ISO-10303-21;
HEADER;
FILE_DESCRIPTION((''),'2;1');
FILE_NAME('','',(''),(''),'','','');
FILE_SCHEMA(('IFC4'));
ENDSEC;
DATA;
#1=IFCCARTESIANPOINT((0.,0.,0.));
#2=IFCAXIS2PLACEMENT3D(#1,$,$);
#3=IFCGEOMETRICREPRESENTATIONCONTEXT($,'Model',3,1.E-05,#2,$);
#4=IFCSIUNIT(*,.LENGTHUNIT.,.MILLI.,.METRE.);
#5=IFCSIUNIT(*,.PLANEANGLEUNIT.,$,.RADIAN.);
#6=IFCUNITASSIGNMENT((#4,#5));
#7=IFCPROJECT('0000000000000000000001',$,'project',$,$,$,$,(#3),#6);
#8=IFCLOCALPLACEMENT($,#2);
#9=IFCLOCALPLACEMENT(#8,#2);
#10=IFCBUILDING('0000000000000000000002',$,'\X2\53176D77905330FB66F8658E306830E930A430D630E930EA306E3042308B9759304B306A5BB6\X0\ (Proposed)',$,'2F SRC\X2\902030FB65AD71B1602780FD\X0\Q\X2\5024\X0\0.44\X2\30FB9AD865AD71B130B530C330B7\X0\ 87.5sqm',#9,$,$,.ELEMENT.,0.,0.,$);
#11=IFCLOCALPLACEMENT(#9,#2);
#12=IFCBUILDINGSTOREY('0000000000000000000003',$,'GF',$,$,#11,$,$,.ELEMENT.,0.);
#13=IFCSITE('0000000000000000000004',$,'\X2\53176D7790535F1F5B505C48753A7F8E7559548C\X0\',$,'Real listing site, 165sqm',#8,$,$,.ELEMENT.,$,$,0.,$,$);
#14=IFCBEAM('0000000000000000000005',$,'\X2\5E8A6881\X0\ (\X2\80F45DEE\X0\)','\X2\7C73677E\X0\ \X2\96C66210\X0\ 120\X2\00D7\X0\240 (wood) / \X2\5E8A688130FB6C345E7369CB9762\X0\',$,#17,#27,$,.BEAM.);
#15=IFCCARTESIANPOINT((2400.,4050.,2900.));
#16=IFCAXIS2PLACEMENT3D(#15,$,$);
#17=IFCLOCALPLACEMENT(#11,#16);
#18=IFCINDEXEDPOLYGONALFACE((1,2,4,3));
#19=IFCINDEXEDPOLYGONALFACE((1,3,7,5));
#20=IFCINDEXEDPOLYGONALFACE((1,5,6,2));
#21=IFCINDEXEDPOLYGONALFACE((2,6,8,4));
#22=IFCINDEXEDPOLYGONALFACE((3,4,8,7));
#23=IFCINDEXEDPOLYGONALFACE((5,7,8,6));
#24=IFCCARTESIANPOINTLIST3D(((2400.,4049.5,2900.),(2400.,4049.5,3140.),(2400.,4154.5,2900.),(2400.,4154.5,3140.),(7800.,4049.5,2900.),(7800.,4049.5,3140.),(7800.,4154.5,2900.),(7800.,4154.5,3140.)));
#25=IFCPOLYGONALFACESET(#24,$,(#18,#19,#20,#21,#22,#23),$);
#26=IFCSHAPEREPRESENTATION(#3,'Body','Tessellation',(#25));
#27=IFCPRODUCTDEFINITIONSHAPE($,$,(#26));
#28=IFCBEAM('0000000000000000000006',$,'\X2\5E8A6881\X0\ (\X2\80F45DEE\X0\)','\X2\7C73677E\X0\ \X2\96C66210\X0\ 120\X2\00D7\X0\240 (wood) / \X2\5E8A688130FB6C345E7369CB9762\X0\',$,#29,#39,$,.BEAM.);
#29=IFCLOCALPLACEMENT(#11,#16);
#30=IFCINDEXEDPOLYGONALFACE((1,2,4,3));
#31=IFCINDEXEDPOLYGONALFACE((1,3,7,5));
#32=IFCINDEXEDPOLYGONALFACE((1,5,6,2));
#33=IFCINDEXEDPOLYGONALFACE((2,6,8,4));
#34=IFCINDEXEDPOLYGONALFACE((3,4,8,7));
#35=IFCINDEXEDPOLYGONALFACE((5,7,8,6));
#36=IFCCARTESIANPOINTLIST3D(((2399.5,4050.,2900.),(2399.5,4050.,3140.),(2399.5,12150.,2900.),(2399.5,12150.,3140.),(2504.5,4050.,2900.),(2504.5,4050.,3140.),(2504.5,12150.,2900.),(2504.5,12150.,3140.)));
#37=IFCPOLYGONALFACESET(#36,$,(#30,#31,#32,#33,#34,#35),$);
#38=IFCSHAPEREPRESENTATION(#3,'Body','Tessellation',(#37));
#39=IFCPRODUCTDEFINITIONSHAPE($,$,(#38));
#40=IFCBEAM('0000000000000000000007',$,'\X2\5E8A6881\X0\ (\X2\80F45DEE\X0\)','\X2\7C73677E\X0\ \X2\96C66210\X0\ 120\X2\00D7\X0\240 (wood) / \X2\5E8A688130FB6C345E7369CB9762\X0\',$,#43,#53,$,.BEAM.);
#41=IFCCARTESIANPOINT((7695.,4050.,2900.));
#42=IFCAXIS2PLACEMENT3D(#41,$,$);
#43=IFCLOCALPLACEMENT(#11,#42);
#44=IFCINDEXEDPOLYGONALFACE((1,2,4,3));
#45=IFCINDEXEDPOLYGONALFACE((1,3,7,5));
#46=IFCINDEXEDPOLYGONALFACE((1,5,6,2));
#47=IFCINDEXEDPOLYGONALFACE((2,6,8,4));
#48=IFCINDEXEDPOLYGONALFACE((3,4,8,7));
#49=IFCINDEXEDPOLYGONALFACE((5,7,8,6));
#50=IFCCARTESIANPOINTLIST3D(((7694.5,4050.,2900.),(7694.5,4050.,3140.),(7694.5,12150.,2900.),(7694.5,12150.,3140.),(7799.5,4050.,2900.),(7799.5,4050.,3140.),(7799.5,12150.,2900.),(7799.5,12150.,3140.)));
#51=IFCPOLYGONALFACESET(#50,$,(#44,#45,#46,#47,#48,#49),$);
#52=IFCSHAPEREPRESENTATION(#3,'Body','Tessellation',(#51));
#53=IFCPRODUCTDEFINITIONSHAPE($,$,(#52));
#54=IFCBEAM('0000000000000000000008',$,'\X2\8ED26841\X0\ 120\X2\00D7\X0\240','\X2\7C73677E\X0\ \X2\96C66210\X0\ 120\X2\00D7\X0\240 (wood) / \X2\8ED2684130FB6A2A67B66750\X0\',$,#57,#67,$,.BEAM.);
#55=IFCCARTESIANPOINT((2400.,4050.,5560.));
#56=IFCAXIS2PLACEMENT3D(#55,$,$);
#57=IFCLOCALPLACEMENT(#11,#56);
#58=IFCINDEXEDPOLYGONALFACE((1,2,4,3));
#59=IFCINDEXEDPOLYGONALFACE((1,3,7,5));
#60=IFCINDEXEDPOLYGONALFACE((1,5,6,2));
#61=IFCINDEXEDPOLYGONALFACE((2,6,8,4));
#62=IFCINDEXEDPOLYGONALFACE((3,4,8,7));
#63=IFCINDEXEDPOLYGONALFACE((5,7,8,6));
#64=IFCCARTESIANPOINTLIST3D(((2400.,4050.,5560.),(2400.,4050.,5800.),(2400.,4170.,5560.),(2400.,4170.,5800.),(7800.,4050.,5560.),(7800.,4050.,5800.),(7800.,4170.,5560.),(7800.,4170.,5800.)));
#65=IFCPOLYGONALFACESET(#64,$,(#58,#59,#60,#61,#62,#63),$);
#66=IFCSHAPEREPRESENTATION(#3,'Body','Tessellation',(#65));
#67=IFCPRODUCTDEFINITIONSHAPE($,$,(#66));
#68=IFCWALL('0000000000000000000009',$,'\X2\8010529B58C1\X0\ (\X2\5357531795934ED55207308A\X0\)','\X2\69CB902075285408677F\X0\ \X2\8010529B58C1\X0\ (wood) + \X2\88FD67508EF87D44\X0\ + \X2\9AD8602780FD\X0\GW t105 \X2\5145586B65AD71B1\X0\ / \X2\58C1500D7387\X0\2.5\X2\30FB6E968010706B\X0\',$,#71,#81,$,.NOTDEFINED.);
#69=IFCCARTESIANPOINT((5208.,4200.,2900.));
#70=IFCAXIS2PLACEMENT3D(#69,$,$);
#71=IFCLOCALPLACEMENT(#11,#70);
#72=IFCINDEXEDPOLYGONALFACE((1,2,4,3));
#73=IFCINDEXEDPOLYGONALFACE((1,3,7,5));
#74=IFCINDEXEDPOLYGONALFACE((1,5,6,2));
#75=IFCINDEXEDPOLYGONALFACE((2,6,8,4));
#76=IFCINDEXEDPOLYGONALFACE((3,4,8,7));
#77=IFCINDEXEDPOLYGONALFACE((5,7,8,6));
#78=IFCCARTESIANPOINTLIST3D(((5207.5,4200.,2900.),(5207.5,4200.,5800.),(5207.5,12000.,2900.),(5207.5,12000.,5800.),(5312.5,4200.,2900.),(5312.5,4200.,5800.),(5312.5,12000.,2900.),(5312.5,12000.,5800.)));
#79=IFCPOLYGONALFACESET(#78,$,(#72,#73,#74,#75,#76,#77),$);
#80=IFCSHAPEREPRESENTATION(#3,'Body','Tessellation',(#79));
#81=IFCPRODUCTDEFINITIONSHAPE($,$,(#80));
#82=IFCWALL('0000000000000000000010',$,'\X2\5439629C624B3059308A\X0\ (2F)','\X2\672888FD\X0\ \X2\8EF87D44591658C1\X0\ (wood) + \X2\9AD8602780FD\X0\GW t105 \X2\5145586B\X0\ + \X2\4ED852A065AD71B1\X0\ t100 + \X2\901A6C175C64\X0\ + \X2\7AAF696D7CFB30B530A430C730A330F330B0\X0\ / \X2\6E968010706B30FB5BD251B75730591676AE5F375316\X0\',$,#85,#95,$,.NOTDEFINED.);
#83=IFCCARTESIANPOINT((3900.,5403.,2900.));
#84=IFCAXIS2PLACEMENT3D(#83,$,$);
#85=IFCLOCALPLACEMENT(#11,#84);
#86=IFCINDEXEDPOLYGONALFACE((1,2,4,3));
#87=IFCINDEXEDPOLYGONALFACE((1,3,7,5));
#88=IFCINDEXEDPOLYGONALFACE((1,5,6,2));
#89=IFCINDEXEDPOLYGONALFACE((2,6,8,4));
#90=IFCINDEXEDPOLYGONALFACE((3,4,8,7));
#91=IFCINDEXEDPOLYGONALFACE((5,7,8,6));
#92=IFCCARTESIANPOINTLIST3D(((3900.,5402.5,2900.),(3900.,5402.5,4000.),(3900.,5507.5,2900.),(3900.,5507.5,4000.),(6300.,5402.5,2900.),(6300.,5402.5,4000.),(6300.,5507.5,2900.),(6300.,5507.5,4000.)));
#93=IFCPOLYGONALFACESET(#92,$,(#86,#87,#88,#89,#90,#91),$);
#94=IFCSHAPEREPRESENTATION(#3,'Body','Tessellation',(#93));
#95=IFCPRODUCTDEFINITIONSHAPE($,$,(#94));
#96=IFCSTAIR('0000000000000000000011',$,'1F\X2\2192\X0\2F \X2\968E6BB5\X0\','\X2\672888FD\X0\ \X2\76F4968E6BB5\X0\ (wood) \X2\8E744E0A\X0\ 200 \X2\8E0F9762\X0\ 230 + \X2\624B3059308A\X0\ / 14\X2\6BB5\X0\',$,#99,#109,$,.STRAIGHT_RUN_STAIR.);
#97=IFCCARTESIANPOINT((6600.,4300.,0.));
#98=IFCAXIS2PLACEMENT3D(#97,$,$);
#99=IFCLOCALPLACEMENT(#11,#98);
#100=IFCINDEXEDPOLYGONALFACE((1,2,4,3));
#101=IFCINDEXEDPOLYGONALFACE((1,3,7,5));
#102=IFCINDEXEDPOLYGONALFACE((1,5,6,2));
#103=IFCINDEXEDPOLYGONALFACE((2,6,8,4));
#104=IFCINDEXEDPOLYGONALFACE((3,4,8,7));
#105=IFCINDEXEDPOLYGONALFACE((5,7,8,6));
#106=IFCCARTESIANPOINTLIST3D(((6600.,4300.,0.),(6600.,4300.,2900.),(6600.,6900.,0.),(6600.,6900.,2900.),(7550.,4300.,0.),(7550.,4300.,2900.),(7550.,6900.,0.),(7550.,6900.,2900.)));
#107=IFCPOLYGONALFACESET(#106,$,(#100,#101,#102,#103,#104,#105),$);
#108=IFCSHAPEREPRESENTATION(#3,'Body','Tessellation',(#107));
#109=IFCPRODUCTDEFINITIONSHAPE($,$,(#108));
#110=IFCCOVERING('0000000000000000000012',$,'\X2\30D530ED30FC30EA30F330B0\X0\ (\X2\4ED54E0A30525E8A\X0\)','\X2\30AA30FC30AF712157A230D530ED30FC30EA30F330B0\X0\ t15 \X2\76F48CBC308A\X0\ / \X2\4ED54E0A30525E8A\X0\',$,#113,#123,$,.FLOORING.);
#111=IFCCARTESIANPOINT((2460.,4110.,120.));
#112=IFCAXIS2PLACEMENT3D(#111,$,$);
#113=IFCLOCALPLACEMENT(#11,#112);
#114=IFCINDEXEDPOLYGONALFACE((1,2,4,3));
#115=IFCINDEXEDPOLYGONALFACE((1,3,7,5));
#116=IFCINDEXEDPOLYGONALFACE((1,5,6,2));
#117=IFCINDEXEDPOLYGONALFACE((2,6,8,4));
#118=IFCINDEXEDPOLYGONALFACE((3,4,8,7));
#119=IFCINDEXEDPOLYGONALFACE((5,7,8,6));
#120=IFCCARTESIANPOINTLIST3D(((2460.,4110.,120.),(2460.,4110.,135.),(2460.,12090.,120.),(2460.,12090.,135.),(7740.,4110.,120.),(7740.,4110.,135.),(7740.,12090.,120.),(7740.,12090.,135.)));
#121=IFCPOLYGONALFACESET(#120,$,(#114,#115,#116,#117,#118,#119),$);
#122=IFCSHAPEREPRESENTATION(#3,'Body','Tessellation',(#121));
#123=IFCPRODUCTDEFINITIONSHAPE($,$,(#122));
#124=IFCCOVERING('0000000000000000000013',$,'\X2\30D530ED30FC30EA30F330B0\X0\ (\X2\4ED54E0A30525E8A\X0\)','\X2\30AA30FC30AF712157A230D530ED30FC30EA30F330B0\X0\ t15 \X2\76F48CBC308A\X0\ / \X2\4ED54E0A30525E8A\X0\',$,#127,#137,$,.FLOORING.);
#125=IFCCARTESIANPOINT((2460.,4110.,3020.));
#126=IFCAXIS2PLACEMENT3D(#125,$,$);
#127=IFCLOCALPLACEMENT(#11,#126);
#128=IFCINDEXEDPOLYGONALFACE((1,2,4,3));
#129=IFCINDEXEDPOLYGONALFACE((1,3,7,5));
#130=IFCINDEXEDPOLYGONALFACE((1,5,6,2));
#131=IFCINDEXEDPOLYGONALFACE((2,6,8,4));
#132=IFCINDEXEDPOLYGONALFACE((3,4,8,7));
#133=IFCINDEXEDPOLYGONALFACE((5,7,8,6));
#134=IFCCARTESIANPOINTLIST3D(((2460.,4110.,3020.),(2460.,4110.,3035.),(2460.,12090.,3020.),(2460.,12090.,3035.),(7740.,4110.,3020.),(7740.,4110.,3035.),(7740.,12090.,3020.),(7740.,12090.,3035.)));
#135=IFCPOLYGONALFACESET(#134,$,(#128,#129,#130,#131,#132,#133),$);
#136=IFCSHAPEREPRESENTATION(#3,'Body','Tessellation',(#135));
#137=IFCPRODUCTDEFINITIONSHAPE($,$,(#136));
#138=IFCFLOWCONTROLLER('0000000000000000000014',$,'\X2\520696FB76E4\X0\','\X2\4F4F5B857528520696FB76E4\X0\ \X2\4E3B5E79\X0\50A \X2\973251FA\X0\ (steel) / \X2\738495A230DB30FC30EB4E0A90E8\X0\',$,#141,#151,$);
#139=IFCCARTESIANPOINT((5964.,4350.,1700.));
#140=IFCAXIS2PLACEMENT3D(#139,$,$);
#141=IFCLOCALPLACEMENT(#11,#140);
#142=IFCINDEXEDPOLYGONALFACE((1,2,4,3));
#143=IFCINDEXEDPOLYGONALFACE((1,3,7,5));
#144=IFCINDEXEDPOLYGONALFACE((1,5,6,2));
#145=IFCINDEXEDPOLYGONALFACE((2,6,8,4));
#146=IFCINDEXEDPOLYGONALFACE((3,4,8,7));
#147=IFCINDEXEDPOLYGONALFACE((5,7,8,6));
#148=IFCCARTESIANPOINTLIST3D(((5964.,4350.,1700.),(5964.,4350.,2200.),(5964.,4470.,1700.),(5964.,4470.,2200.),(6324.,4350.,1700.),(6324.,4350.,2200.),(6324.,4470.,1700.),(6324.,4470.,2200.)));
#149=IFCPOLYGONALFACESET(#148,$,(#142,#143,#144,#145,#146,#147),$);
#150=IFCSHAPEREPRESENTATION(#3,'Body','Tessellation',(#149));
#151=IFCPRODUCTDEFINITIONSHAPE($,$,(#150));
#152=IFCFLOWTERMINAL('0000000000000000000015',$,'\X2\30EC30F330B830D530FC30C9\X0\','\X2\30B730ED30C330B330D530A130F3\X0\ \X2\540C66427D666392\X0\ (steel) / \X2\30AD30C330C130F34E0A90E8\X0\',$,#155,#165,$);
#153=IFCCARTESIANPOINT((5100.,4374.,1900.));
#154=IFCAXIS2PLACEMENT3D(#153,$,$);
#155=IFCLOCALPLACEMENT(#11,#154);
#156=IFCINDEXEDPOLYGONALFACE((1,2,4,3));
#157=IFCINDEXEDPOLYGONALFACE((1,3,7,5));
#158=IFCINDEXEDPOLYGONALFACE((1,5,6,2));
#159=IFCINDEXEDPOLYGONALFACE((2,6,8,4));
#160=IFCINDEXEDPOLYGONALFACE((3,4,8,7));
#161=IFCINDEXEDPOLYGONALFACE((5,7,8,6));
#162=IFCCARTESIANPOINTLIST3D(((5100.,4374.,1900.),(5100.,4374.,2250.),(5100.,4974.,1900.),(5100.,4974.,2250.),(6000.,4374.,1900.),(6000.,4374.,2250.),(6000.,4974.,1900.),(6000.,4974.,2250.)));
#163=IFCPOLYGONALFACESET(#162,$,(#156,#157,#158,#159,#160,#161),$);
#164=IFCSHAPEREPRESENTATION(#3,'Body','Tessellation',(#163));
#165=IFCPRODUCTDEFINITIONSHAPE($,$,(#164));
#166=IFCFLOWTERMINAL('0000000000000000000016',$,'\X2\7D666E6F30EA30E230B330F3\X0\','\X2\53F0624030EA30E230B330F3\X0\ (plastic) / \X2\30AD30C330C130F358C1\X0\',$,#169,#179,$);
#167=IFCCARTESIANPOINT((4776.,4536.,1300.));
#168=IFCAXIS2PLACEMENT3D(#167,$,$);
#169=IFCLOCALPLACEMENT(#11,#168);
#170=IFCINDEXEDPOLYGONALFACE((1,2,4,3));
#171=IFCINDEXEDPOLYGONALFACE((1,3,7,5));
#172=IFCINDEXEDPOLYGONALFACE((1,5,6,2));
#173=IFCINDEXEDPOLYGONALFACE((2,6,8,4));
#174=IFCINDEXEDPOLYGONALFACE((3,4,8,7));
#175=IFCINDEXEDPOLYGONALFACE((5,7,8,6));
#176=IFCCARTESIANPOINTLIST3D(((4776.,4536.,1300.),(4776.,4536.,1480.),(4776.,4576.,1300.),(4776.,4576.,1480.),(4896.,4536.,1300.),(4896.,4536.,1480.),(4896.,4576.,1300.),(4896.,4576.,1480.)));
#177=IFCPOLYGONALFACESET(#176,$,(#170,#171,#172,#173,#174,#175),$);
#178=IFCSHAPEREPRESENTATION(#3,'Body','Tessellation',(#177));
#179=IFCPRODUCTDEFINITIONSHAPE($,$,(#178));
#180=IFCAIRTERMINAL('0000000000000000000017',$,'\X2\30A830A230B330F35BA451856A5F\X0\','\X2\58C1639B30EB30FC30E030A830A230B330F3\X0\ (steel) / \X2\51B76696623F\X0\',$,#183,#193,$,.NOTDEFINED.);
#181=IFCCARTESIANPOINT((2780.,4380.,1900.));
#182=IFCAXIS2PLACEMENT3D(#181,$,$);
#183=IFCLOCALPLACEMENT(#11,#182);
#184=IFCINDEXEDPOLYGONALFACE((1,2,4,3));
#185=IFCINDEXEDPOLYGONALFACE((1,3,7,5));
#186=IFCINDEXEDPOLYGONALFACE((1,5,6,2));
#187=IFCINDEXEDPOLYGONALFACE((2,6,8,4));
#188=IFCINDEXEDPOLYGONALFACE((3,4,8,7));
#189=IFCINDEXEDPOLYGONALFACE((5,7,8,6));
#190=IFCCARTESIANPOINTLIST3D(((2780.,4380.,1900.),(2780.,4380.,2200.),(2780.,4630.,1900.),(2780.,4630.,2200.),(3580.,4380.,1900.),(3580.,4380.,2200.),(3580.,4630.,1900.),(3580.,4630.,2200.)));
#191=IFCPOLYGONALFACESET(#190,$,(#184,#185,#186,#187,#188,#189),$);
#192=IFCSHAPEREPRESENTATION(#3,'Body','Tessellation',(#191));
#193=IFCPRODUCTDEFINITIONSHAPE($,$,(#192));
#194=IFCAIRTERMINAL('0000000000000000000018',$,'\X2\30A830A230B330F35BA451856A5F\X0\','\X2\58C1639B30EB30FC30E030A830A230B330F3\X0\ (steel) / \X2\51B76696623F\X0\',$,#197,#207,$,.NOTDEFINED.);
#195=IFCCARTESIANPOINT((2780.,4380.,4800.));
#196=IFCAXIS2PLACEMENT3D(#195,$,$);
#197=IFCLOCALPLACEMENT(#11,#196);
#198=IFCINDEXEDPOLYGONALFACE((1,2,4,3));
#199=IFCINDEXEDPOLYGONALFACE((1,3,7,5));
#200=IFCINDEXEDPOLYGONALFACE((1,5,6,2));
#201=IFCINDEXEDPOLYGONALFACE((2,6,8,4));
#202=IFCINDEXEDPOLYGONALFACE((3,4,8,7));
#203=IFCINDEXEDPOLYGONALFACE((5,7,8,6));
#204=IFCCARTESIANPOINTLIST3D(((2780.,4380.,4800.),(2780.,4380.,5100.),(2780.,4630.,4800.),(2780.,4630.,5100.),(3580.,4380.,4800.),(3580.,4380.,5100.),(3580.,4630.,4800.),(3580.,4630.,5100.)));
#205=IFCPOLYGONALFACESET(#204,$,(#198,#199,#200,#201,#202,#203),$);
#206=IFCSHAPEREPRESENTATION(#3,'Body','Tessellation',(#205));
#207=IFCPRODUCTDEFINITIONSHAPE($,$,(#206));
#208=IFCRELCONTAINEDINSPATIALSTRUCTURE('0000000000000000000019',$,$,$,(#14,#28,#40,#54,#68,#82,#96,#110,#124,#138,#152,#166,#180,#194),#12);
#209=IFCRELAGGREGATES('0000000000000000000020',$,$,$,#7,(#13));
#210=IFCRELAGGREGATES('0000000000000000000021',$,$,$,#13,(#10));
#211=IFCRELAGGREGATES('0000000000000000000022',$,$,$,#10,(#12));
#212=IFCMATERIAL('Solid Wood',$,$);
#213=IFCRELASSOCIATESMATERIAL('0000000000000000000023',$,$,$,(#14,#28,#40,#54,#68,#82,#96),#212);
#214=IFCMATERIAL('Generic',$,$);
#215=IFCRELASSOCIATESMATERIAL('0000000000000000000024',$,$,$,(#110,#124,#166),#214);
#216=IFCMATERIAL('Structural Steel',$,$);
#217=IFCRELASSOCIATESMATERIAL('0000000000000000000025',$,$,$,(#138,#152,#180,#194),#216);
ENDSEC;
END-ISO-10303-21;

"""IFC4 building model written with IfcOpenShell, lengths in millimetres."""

from ifc_helpers import new_model, si_unit, frame, frame_2d, origin, place, context, project, spatial, rectangle, extrude, material, element, save


model = new_model("IFC4")

# Units and contexts
model_context = context("Model", 3, precision=1e-05, world=origin())
ifc_project = project(units=[si_unit("LENGTHUNIT", "METRE", prefix="MILLI"), si_unit("PLANEANGLEUNIT", "RADIAN")], contexts=[model_context])

# Site, building, storey
site_placement = place(None, origin())
site = spatial("IfcSite", under=ifc_project, at=site_placement, Name="北海道弟子屈町美留和", ObjectType="Real listing site, 165sqm", CompositionType="ELEMENT", RefElevation=0.0)
building_placement = place(site_placement, origin())
building = spatial("IfcBuilding", under=site, at=building_placement, Name="北海道・書斎とライブラリのある静かな家 (Proposed)", ObjectType="2F SRC造・断熱性能Q値0.44・高断熱サッシ 87.5sqm", CompositionType="ELEMENT", ElevationOfRefHeight=0.0, ElevationOfTerrain=0.0)
storey_placement = place(building_placement, origin())
storey = spatial("IfcBuildingStorey", under=building, at=storey_placement, Name="GF", CompositionType="ELEMENT", Elevation=0.0)

# Shared definitions
ifc_material_1 = material(Name="Solid Wood")

# Beams
beam_1_placement = place(storey_placement, frame((2400.0, 4050.0, 2900.0)))
element("IfcBeam", 1, at=beam_1_placement, inside=storey, material=ifc_material_1, Name="床梁 (胴差)", Description="米松 集成 120×240 (wood) / 床梁・水平構面", PredefinedType="BEAM", context=model_context, shape_type="SweptSolid", body=[
    extrude(rectangle(XDim=5400.0, YDim=105.0, at=frame_2d((2700.0, 52.0))), frame((2400.0, 4050.0, 2900.0)), (0.0, 0.0, 1.0), 240.0),
])
beam_2_placement = place(storey_placement, frame((2400.0, 4050.0, 2900.0)))
element("IfcBeam", 2, at=beam_2_placement, inside=storey, material=ifc_material_1, Name="床梁 (胴差)", Description="米松 集成 120×240 (wood) / 床梁・水平構面", PredefinedType="BEAM", context=model_context, shape_type="SweptSolid", body=[
    extrude(rectangle(XDim=105.0, YDim=8100.0, at=frame_2d((52.0, 4050.0))), frame((2400.0, 4050.0, 2900.0)), (0.0, 0.0, 1.0), 240.0),
])
beam_3_placement = place(storey_placement, frame((7695.0, 4050.0, 2900.0)))
element("IfcBeam", 3, at=beam_3_placement, inside=storey, material=ifc_material_1, Name="床梁 (胴差)", Description="米松 集成 120×240 (wood) / 床梁・水平構面", PredefinedType="BEAM", context=model_context, shape_type="SweptSolid", body=[
    extrude(rectangle(XDim=105.0, YDim=8100.0, at=frame_2d((52.0, 4050.0))), frame((7695.0, 4050.0, 2900.0)), (0.0, 0.0, 1.0), 240.0),
])
beam_4_placement = place(storey_placement, frame((2400.0, 4050.0, 5560.0)))
element("IfcBeam", 4, at=beam_4_placement, inside=storey, material=ifc_material_1, Name="軒桁 120×240", Description="米松 集成 120×240 (wood) / 軒桁・横架材", PredefinedType="BEAM", context=model_context, shape_type="SweptSolid", body=[
    extrude(rectangle(XDim=5400.0, YDim=120.0, at=frame_2d((2700.0, 60.0))), frame((2400.0, 4050.0, 5560.0)), (0.0, 0.0, 1.0), 240.0),
])

# Walls
wall_1_placement = place(storey_placement, frame((5208.0, 4200.0, 2900.0)))
element("IfcWall", 5, at=wall_1_placement, inside=storey, material=ifc_material_1, Name="耐力壁 (南北間仕切り)", Description="構造用合板 耐力壁 (wood) + 製材軸組 + 高性能GW t105 充填断熱 / 壁倍率2.5・準耐火", PredefinedType="NOTDEFINED", context=model_context, shape_type="SweptSolid", body=[
    extrude(rectangle(XDim=105.0, YDim=7800.0, at=frame_2d((52.0, 3900.0))), frame((5208.0, 4200.0, 2900.0)), (0.0, 0.0, 1.0), 2900.0),
])
wall_2_placement = place(storey_placement, frame((3900.0, 5403.0, 2900.0)))
element("IfcWall", 6, at=wall_2_placement, inside=storey, material=ifc_material_1, Name="吹抜手すり (2F)", Description="木製 軸組外壁 (wood) + 高性能GW t105 充填 + 付加断熱 t100 + 通気層 + 窯業系サイディング / 準耐火・寒冷地外皮強化", PredefinedType="NOTDEFINED", context=model_context, shape_type="SweptSolid", body=[
    extrude(rectangle(XDim=2400.0, YDim=105.0, at=frame_2d((1200.0, 52.0))), frame((3900.0, 5403.0, 2900.0)), (0.0, 0.0, 1.0), 1100.0),
])

# Stair
stair_placement = place(storey_placement, frame((6600.0, 4300.0, 0.0)))
element("IfcStair", 7, at=stair_placement, inside=storey, material=ifc_material_1, Name="1F→2F 階段", Description="木製 直階段 (wood) 蹴上 200 踏面 230 + 手すり / 14段", PredefinedType="STRAIGHT_RUN_STAIR", context=model_context, shape_type="SweptSolid", body=[
    extrude(rectangle(XDim=950.0, YDim=2600.0, at=frame_2d((475.0, 1300.0))), frame((6600.0, 4300.0, 0.0)), (0.0, 0.0, 1.0), 2900.0),
])

# Coverings
ifc_material_2 = material(Name="Generic")
covering_1_placement = place(storey_placement, frame((2460.0, 4110.0, 120.0)))
element("IfcCovering", 8, at=covering_1_placement, inside=storey, material=ifc_material_2, Name="フローリング (仕上げ床)", Description="オーク無垢フローリング t15 直貼り / 仕上げ床", PredefinedType="FLOORING", context=model_context, shape_type="SweptSolid", body=[
    extrude(rectangle(XDim=5280.0, YDim=7980.0, at=frame_2d((2640.0, 3990.0))), frame((2460.0, 4110.0, 120.0)), (0.0, 0.0, 1.0), 15.0),
])
covering_2_placement = place(storey_placement, frame((2460.0, 4110.0, 3020.0)))
element("IfcCovering", 9, at=covering_2_placement, inside=storey, material=ifc_material_2, Name="フローリング (仕上げ床)", Description="オーク無垢フローリング t15 直貼り / 仕上げ床", PredefinedType="FLOORING", context=model_context, shape_type="SweptSolid", body=[
    extrude(rectangle(XDim=5280.0, YDim=7980.0, at=frame_2d((2640.0, 3990.0))), frame((2460.0, 4110.0, 3020.0)), (0.0, 0.0, 1.0), 15.0),
])

# Flow controller
ifc_material_3 = material(Name="Structural Steel")
flow_controller_placement = place(storey_placement, frame((5964.0, 4350.0, 1700.0)))
element("IfcFlowController", 10, at=flow_controller_placement, inside=storey, material=ifc_material_3, Name="分電盤", Description="住宅用分電盤 主幹50A 露出 (steel) / 玄関ホール上部", context=model_context, shape_type="SweptSolid", body=[
    extrude(rectangle(XDim=360.0, YDim=120.0, at=frame_2d((180.0, 60.0))), frame((5964.0, 4350.0, 1700.0)), (0.0, 0.0, 1.0), 500.0),
])

# Flow terminals
flow_terminal_1_placement = place(storey_placement, frame((5100.0, 4374.0, 1900.0)))
element("IfcFlowTerminal", 11, at=flow_terminal_1_placement, inside=storey, material=ifc_material_3, Name="レンジフード", Description="シロッコファン 同時給排 (steel) / キッチン上部", context=model_context, shape_type="SweptSolid", body=[
    extrude(rectangle(XDim=900.0, YDim=600.0, at=frame_2d((450.0, 300.0))), frame((5100.0, 4374.0, 1900.0)), (0.0, 0.0, 1.0), 350.0),
])
flow_terminal_2_placement = place(storey_placement, frame((4776.0, 4536.0, 1300.0)))
element("IfcFlowTerminal", 12, at=flow_terminal_2_placement, inside=storey, material=ifc_material_2, Name="給湯リモコン", Description="台所リモコン (plastic) / キッチン壁", context=model_context, shape_type="SweptSolid", body=[
    extrude(rectangle(XDim=120.0, YDim=40.0, at=frame_2d((60.0, 20.0))), frame((4776.0, 4536.0, 1300.0)), (0.0, 0.0, 1.0), 180.0),
])

# Air terminals
air_terminal_1_placement = place(storey_placement, frame((2780.0, 4380.0, 1900.0)))
element("IfcAirTerminal", 13, at=air_terminal_1_placement, inside=storey, material=ifc_material_3, Name="エアコン室内機", Description="壁掛ルームエアコン (steel) / 冷暖房", PredefinedType="NOTDEFINED", context=model_context, shape_type="SweptSolid", body=[
    extrude(rectangle(XDim=800.0, YDim=250.0, at=frame_2d((400.0, 125.0))), frame((2780.0, 4380.0, 1900.0)), (0.0, 0.0, 1.0), 300.0),
])
air_terminal_2_placement = place(storey_placement, frame((2780.0, 4380.0, 4800.0)))
element("IfcAirTerminal", 14, at=air_terminal_2_placement, inside=storey, material=ifc_material_3, Name="エアコン室内機", Description="壁掛ルームエアコン (steel) / 冷暖房", PredefinedType="NOTDEFINED", context=model_context, shape_type="SweptSolid", body=[
    extrude(rectangle(XDim=800.0, YDim=250.0, at=frame_2d((400.0, 125.0))), frame((2780.0, 4380.0, 4800.0)), (0.0, 0.0, 1.0), 300.0),
])

save(model, "model.ifc")
